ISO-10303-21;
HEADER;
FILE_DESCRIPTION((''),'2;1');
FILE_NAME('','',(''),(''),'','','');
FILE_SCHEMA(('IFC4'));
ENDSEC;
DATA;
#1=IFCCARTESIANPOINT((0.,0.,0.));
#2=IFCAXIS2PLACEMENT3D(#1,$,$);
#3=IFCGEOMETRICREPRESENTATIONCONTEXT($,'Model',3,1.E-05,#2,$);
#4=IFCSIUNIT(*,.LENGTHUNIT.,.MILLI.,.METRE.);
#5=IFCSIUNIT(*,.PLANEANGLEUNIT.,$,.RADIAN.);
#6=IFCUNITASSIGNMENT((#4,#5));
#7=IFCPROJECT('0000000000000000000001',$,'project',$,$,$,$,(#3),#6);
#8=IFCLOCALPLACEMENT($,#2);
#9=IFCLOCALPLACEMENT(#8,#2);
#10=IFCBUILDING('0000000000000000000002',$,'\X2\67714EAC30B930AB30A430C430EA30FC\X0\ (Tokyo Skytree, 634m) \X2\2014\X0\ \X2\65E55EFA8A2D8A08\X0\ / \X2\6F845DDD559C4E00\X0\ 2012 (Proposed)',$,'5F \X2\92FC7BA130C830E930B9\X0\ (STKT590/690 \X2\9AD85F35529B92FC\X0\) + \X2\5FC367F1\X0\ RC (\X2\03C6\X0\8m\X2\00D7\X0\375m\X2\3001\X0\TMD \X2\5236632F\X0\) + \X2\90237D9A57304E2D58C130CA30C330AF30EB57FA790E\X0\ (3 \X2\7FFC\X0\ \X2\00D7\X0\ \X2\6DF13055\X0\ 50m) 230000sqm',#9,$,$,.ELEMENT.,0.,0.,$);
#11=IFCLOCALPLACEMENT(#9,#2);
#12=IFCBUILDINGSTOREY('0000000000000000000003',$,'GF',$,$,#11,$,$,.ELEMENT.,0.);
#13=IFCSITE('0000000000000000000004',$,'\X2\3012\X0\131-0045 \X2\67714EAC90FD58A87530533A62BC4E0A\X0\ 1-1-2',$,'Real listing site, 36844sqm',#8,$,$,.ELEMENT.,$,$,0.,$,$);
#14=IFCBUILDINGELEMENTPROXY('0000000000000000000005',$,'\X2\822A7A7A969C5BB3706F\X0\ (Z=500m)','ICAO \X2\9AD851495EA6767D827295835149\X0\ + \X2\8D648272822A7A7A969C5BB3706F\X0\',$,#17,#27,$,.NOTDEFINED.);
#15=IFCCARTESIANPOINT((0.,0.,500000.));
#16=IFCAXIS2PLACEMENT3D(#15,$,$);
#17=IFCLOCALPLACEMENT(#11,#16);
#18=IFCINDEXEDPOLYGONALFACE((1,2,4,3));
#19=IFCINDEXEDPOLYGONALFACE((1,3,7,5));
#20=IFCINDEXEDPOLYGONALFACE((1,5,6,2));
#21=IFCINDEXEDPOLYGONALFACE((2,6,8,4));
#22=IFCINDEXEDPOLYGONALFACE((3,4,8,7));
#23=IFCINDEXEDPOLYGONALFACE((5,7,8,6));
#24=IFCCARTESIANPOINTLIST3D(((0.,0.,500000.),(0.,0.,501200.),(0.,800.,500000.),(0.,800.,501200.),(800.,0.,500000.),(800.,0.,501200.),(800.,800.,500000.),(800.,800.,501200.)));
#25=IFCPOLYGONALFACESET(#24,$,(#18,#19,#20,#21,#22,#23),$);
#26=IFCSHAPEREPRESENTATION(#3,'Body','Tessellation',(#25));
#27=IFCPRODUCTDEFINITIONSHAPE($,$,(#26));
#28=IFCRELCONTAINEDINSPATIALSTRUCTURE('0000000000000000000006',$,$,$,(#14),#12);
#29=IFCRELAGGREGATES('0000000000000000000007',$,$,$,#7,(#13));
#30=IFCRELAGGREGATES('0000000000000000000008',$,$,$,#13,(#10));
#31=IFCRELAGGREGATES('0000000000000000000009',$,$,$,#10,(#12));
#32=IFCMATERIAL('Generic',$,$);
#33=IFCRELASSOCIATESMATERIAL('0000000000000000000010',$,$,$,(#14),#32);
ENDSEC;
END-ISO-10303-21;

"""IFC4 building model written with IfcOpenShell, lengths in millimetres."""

from ifc_helpers import new_model, si_unit, frame, frame_2d, origin, place, context, project, spatial, rectangle, extrude, material, element, save


model = new_model("IFC4")

# Units and contexts
model_context = context("Model", 3, precision=1e-05, world=origin())
ifc_project = project(units=[si_unit("LENGTHUNIT", "METRE", prefix="MILLI"), si_unit("PLANEANGLEUNIT", "RADIAN")], contexts=[model_context])

# Site, building, storey
site_placement = place(None, origin())
site = spatial("IfcSite", under=ifc_project, at=site_placement, Name="〒131-0045 東京都墨田区押上 1-1-2", ObjectType="Real listing site, 36844sqm", CompositionType="ELEMENT", RefElevation=0.0)
building_placement = place(site_placement, origin())
building = spatial("IfcBuilding", under=site, at=building_placement, Name="東京スカイツリー (Tokyo Skytree, 634m) — 日建設計 / 澄川喜一 2012 (Proposed)", ObjectType="5F 鋼管トラス (STKT590/690 高張力鋼) + 心柱 RC (φ8m×375m、TMD 制振) + 連続地中壁ナックル基礎 (3 翼 × 深さ 50m) 230000sqm", CompositionType="ELEMENT", ElevationOfRefHeight=0.0, ElevationOfTerrain=0.0)
storey_placement = place(building_placement, origin())
storey = spatial("IfcBuildingStorey", under=building, at=storey_placement, Name="GF", CompositionType="ELEMENT", Elevation=0.0)

# Shared definitions
ifc_material = material(Name="Generic")

# Building element proxy
proxy_placement = place(storey_placement, frame((0.0, 0.0, 500000.0)))
element("IfcBuildingElementProxy", 1, at=proxy_placement, inside=storey, material=ifc_material, Name="航空障害灯 (Z=500m)", Description="ICAO 高光度白色閃光 + 赤色航空障害灯", PredefinedType="NOTDEFINED", context=model_context, shape_type="SweptSolid", body=[
    extrude(rectangle(XDim=800.0, YDim=800.0, at=frame_2d((400.0, 400.0))), frame((0.0, 0.0, 500000.0)), (0.0, 0.0, 1.0), 1200.0),
])

save(model, "model.ifc")
